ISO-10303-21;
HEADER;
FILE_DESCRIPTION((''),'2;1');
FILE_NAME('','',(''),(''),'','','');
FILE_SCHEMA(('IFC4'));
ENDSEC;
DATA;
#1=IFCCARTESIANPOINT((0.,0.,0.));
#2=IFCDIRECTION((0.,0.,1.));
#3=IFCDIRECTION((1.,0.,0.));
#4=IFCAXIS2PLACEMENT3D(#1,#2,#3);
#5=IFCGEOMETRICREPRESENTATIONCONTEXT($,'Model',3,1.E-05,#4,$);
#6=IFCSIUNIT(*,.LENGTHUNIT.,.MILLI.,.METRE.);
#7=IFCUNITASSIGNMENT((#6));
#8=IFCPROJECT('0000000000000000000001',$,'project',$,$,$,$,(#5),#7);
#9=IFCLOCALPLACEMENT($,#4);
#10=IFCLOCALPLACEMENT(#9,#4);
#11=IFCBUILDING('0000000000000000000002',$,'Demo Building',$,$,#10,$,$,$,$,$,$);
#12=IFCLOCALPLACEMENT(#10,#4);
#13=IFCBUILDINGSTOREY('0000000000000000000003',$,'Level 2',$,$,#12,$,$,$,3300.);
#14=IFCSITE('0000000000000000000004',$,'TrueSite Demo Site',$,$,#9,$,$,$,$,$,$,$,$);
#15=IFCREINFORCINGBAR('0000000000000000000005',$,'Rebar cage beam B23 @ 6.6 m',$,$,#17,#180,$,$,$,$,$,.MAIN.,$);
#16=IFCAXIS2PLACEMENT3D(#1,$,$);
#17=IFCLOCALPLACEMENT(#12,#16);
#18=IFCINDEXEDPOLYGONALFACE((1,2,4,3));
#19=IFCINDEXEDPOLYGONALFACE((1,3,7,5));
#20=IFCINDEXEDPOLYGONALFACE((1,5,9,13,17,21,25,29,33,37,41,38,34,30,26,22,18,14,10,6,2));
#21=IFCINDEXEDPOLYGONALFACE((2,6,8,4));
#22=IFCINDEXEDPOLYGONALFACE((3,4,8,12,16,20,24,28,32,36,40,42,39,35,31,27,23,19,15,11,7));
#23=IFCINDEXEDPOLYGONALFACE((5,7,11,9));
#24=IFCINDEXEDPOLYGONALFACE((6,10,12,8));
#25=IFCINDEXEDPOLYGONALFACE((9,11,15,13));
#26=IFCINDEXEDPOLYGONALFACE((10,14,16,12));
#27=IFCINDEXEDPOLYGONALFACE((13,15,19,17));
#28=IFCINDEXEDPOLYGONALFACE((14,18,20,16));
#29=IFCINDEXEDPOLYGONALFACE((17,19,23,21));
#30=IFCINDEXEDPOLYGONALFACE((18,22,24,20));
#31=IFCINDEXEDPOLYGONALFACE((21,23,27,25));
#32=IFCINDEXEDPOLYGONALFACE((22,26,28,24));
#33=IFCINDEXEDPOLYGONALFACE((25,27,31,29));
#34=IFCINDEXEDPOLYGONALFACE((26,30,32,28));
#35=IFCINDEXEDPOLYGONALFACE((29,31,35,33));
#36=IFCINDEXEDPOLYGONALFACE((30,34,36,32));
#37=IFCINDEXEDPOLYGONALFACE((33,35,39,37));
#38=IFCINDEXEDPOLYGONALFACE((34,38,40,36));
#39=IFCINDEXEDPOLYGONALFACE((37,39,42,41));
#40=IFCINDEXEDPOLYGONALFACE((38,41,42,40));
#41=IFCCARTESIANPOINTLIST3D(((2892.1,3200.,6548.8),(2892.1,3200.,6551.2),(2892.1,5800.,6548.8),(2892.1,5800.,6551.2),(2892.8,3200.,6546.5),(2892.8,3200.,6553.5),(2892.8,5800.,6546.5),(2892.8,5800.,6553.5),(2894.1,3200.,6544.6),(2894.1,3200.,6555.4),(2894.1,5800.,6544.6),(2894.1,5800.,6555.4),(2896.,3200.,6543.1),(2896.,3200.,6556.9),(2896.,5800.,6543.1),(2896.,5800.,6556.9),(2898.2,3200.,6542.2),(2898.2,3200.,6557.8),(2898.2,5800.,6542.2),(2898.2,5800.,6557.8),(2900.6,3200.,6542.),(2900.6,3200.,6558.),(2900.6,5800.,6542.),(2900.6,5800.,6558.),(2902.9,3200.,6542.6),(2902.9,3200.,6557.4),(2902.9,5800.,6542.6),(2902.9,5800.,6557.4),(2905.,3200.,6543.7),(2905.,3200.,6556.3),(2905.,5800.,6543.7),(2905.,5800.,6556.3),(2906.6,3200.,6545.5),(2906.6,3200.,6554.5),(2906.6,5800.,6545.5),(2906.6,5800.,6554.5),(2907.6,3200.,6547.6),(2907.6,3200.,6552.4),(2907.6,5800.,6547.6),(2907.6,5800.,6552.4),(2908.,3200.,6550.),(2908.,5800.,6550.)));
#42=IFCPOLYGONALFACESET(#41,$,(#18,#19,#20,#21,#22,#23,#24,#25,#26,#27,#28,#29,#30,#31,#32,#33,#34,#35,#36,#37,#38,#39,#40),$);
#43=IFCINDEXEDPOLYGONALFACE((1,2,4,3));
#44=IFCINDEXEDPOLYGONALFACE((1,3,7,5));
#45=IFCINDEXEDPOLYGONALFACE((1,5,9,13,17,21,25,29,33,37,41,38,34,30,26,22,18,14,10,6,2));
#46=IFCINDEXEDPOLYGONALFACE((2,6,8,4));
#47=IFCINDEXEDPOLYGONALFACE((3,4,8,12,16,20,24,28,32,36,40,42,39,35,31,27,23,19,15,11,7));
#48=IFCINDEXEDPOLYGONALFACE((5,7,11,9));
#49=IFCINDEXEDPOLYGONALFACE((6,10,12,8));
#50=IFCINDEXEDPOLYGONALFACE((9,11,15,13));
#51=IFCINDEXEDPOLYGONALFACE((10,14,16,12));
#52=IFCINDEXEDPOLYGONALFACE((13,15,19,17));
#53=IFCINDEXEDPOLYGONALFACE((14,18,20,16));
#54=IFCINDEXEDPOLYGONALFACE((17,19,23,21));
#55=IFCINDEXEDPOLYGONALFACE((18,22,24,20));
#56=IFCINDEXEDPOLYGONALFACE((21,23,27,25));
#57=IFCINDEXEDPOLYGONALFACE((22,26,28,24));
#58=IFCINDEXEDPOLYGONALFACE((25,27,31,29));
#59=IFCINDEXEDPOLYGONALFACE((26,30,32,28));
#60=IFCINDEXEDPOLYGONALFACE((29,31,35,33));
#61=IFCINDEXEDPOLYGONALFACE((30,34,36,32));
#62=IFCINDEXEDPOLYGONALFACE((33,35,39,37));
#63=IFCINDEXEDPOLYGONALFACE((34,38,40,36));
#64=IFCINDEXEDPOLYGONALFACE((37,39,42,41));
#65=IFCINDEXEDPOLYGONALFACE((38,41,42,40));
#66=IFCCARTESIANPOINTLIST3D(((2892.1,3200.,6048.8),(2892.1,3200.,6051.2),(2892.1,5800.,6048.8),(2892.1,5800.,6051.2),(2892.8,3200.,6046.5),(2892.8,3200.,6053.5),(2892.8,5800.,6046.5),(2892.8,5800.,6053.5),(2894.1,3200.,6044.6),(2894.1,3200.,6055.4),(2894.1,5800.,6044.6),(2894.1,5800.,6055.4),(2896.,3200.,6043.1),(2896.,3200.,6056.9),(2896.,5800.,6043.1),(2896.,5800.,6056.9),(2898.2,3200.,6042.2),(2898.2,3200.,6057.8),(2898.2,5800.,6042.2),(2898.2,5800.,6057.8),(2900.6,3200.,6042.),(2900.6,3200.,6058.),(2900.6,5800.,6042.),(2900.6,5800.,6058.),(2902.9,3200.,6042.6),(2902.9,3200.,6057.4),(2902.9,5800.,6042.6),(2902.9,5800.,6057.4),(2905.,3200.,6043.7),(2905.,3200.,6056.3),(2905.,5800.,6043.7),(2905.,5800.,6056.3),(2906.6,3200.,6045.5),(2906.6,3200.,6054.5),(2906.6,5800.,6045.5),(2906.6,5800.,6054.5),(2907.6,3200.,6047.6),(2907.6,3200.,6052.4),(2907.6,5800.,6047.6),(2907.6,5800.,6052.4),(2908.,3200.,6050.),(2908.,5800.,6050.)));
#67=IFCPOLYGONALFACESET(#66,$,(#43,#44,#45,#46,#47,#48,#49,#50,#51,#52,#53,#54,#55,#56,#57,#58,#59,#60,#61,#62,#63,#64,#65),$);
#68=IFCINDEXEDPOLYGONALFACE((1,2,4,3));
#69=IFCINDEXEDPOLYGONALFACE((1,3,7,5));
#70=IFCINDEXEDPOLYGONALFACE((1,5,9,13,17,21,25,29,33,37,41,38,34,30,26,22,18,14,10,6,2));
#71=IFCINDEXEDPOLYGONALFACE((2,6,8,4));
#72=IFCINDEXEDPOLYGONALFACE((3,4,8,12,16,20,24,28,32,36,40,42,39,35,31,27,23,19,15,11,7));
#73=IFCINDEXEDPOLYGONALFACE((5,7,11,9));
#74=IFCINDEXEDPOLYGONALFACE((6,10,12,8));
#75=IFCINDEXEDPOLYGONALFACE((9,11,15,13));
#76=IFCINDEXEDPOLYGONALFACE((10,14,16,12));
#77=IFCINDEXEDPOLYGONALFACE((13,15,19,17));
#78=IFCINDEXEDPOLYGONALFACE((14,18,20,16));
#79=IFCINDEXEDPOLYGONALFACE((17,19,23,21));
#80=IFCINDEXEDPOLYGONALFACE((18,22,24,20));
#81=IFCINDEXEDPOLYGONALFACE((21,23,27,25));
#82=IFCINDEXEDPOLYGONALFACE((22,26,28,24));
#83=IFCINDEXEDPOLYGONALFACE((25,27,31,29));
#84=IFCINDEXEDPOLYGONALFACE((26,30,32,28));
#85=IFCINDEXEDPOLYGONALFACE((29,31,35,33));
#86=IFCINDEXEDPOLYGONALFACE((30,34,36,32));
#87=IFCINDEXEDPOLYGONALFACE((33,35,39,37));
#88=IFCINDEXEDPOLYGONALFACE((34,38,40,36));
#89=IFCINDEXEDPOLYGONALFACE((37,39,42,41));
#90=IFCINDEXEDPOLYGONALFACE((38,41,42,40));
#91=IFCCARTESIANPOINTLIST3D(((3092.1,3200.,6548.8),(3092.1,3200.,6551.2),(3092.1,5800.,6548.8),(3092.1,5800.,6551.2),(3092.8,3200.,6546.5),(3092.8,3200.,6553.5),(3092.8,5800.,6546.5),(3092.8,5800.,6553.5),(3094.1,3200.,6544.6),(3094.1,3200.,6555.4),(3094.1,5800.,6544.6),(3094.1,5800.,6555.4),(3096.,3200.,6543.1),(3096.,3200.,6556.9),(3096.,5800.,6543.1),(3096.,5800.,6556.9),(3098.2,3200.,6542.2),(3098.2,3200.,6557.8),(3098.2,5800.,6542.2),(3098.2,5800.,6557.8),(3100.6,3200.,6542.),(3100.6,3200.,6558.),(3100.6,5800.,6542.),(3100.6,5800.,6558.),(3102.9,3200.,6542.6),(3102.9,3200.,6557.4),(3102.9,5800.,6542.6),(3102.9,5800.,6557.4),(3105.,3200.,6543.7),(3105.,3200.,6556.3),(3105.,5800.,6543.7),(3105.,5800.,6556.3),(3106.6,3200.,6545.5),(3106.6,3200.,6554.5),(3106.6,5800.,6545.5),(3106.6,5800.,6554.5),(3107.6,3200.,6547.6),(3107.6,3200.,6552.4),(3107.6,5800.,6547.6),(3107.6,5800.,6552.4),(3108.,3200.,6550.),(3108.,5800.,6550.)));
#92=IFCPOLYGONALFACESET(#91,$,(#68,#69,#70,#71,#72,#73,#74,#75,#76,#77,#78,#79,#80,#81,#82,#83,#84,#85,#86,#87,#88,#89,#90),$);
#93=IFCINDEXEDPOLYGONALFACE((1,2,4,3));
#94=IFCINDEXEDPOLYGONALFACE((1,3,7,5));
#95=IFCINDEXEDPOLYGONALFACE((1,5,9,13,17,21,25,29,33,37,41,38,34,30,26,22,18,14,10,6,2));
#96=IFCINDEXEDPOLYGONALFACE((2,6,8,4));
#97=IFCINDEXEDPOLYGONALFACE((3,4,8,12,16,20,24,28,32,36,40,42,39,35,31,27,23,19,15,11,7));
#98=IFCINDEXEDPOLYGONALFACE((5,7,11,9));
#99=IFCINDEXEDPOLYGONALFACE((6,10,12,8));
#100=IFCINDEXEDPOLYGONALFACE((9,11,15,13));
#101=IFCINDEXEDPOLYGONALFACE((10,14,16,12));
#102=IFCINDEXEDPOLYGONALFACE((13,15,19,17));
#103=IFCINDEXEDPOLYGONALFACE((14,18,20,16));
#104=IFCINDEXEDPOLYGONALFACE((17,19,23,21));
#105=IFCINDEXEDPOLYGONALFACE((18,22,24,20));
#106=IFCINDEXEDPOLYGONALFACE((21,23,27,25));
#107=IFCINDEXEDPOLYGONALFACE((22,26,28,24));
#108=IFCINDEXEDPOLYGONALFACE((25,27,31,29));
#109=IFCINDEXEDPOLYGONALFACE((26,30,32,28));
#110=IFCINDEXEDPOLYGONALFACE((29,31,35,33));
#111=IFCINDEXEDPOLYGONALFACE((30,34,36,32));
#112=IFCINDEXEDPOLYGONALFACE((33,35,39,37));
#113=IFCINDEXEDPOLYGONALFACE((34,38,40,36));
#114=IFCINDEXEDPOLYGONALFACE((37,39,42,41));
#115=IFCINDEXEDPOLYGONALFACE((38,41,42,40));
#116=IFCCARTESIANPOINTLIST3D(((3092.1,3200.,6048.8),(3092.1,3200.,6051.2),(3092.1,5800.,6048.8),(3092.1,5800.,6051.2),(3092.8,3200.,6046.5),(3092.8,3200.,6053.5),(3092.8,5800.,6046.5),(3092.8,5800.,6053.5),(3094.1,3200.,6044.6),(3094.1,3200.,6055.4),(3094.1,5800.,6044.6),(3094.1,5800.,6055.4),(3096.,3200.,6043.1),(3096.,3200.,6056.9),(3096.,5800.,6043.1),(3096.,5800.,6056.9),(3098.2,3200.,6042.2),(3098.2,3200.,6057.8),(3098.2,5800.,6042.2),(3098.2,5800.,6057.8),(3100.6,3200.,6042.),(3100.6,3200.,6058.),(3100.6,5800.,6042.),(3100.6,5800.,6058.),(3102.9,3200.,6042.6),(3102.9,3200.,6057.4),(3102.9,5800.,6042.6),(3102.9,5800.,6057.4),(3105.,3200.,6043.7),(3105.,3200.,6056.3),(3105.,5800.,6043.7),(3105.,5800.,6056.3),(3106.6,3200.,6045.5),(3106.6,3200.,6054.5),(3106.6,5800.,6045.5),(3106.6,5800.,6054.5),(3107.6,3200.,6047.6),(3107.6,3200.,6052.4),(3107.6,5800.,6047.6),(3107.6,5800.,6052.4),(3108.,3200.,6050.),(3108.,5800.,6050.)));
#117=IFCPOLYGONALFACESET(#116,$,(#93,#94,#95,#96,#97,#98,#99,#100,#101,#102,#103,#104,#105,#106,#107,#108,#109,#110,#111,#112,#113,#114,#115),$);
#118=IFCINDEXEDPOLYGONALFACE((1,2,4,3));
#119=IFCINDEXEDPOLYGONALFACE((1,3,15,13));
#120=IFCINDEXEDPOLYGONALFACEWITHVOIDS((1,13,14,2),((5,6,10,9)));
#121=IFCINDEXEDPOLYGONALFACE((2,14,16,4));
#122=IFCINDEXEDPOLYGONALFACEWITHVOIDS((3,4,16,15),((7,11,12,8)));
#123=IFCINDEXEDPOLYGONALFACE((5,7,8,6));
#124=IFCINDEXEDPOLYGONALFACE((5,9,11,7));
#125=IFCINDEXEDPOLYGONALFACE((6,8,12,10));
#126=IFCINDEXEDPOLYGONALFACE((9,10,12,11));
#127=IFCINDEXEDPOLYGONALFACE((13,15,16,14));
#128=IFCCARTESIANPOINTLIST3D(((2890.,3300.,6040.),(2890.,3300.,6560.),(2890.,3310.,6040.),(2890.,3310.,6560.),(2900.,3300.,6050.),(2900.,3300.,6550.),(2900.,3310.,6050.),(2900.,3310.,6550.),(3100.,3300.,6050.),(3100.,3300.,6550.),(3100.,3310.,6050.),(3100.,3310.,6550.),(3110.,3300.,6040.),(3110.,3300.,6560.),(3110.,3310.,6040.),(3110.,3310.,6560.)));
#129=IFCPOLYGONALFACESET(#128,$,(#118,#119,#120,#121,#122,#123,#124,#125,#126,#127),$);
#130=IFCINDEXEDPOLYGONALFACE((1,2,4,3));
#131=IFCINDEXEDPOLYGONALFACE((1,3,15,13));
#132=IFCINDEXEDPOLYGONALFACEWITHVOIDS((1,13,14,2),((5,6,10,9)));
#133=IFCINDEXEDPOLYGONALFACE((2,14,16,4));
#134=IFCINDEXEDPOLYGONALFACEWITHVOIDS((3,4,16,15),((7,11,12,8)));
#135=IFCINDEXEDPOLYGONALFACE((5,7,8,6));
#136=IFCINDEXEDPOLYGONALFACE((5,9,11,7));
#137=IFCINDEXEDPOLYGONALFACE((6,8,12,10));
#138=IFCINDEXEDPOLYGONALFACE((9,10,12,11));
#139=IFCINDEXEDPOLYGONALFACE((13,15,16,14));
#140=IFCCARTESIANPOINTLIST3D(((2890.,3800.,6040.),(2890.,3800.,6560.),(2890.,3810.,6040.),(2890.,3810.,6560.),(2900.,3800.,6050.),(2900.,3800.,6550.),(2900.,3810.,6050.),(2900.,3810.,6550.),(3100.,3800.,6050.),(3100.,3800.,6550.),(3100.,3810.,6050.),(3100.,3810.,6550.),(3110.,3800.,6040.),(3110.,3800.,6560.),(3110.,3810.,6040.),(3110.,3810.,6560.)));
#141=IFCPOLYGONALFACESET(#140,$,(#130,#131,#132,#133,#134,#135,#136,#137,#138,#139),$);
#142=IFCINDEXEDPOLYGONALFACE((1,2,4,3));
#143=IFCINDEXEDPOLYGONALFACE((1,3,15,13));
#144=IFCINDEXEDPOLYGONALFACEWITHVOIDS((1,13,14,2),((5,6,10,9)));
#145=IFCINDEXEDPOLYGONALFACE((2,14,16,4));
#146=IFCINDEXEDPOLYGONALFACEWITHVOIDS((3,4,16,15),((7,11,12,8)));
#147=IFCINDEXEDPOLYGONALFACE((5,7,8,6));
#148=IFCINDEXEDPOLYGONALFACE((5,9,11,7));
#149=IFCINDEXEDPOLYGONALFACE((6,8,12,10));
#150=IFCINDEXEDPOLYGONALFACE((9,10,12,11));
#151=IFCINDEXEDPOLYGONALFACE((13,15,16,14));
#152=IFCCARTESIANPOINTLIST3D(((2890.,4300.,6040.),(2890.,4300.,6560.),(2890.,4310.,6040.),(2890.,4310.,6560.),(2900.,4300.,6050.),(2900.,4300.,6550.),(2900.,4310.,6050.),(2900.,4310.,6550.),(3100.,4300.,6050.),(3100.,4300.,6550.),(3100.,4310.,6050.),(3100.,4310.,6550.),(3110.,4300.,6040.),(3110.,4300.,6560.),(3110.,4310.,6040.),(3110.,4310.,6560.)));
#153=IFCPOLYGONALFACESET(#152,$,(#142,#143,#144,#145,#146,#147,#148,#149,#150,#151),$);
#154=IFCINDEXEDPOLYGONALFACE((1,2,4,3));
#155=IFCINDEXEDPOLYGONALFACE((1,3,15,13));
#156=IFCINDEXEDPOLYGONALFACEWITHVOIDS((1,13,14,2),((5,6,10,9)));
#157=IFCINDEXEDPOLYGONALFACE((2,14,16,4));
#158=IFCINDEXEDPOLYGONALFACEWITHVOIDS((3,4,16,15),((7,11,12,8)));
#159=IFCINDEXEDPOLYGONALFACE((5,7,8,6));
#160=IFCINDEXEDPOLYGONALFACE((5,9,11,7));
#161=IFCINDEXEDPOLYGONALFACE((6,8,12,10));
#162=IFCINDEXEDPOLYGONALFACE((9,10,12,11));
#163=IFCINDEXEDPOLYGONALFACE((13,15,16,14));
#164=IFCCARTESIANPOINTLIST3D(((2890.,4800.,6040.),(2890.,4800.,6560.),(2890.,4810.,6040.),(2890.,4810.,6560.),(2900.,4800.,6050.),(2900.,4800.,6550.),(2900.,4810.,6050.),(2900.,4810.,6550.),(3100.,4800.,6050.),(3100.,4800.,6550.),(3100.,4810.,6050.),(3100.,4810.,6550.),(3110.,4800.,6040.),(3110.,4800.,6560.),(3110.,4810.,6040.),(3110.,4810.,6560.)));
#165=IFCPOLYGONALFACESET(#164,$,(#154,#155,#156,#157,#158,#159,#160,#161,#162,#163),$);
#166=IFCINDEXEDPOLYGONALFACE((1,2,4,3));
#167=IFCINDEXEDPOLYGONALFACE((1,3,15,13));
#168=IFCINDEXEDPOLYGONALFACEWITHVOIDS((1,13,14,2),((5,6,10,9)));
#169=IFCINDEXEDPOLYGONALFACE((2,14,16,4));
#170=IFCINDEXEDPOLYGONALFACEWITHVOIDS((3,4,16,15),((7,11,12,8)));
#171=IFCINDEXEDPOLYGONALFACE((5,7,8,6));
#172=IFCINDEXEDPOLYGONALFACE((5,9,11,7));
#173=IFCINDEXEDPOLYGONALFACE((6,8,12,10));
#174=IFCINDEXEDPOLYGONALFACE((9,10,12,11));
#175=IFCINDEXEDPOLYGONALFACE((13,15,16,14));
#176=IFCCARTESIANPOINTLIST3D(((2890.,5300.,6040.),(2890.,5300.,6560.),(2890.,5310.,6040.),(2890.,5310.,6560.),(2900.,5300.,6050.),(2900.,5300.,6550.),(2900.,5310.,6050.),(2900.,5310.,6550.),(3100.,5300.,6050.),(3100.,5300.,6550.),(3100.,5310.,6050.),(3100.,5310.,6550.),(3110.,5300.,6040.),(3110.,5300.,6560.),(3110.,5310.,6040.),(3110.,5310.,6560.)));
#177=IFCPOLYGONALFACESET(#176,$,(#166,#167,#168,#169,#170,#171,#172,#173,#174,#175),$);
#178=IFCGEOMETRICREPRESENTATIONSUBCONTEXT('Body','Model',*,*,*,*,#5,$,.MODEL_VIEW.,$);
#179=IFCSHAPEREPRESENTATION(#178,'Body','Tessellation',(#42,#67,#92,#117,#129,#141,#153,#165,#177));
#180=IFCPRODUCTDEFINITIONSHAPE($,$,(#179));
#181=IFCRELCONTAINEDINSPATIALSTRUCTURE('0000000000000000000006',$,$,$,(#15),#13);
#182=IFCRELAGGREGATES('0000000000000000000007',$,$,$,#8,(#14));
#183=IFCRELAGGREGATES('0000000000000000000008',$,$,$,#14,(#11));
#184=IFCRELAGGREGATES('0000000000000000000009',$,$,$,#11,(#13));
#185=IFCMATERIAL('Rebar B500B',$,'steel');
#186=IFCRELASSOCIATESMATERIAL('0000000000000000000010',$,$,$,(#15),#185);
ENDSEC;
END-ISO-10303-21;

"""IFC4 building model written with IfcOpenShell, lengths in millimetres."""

from ifc_helpers import new_model, si_unit, frame, origin_with_axes, place, context, subcontext, project, spatial, hollow_rectangle, circle, extrude, material, element, save


model = new_model("IFC4")

# Units and contexts
model_context = context("Model", 3, precision=1e-05, world=origin_with_axes())
body_context = subcontext(model_context, "Body", "Model", "MODEL_VIEW")
ifc_project = project(units=[si_unit("LENGTHUNIT", "METRE", prefix="MILLI")], contexts=[model_context])

# Site, building, storey
site_placement = place(None, origin_with_axes())
site = spatial("IfcSite", under=ifc_project, at=site_placement, Name="TrueSite Demo Site")
building_placement = place(site_placement, origin_with_axes())
building = spatial("IfcBuilding", under=site, at=building_placement, Name="Demo Building")
storey_placement = place(building_placement, origin_with_axes())
storey = spatial("IfcBuildingStorey", under=building, at=storey_placement, Name="Level 2", Elevation=3300.0)

# Reinforcing bar
ifc_material_1 = material(Name="Rebar B500B", Category="steel")
for number, where, z_axis, x_axis, name in (
    (1, (3000.0, 3200.0, 6300.0), (0.0, 1.0, 0.0), (1.0, 0.0, 0.0), "Rebar cage beam B23 @ 6.6 m"),
):
    element("IfcReinforcingBar", number, at=place(storey_placement, frame(where, z_axis=z_axis, x_axis=x_axis)), inside=storey, material=ifc_material_1, Name=name, PredefinedType="MAIN", context=body_context, shape_type="SweptSolid", body=[
        extrude(circle(Radius=8.0), frame((-100.0, -250.0, 0.0)), (0.0, 0.0, 1.0), 2600.0),
        extrude(circle(Radius=8.0), frame((-100.0, 250.0, 0.0)), (0.0, 0.0, 1.0), 2600.0),
        extrude(circle(Radius=8.0), frame((100.0, -250.0, 0.0)), (0.0, 0.0, 1.0), 2600.0),
        extrude(circle(Radius=8.0), frame((100.0, 250.0, 0.0)), (0.0, 0.0, 1.0), 2600.0),
        extrude(hollow_rectangle(XDim=220.0, YDim=520.0, WallThickness=10.0), frame((0.0, 0.0, 100.0)), (0.0, 0.0, 1.0), 10.0),
        extrude(hollow_rectangle(XDim=220.0, YDim=520.0, WallThickness=10.0), frame((0.0, 0.0, 600.0)), (0.0, 0.0, 1.0), 10.0),
        extrude(hollow_rectangle(XDim=220.0, YDim=520.0, WallThickness=10.0), frame((0.0, 0.0, 1100.0)), (0.0, 0.0, 1.0), 10.0),
        extrude(hollow_rectangle(XDim=220.0, YDim=520.0, WallThickness=10.0), frame((0.0, 0.0, 1600.0)), (0.0, 0.0, 1.0), 10.0),
        extrude(hollow_rectangle(XDim=220.0, YDim=520.0, WallThickness=10.0), frame((0.0, 0.0, 2100.0)), (0.0, 0.0, 1.0), 10.0),
    ])

save(model, "model.ifc")
